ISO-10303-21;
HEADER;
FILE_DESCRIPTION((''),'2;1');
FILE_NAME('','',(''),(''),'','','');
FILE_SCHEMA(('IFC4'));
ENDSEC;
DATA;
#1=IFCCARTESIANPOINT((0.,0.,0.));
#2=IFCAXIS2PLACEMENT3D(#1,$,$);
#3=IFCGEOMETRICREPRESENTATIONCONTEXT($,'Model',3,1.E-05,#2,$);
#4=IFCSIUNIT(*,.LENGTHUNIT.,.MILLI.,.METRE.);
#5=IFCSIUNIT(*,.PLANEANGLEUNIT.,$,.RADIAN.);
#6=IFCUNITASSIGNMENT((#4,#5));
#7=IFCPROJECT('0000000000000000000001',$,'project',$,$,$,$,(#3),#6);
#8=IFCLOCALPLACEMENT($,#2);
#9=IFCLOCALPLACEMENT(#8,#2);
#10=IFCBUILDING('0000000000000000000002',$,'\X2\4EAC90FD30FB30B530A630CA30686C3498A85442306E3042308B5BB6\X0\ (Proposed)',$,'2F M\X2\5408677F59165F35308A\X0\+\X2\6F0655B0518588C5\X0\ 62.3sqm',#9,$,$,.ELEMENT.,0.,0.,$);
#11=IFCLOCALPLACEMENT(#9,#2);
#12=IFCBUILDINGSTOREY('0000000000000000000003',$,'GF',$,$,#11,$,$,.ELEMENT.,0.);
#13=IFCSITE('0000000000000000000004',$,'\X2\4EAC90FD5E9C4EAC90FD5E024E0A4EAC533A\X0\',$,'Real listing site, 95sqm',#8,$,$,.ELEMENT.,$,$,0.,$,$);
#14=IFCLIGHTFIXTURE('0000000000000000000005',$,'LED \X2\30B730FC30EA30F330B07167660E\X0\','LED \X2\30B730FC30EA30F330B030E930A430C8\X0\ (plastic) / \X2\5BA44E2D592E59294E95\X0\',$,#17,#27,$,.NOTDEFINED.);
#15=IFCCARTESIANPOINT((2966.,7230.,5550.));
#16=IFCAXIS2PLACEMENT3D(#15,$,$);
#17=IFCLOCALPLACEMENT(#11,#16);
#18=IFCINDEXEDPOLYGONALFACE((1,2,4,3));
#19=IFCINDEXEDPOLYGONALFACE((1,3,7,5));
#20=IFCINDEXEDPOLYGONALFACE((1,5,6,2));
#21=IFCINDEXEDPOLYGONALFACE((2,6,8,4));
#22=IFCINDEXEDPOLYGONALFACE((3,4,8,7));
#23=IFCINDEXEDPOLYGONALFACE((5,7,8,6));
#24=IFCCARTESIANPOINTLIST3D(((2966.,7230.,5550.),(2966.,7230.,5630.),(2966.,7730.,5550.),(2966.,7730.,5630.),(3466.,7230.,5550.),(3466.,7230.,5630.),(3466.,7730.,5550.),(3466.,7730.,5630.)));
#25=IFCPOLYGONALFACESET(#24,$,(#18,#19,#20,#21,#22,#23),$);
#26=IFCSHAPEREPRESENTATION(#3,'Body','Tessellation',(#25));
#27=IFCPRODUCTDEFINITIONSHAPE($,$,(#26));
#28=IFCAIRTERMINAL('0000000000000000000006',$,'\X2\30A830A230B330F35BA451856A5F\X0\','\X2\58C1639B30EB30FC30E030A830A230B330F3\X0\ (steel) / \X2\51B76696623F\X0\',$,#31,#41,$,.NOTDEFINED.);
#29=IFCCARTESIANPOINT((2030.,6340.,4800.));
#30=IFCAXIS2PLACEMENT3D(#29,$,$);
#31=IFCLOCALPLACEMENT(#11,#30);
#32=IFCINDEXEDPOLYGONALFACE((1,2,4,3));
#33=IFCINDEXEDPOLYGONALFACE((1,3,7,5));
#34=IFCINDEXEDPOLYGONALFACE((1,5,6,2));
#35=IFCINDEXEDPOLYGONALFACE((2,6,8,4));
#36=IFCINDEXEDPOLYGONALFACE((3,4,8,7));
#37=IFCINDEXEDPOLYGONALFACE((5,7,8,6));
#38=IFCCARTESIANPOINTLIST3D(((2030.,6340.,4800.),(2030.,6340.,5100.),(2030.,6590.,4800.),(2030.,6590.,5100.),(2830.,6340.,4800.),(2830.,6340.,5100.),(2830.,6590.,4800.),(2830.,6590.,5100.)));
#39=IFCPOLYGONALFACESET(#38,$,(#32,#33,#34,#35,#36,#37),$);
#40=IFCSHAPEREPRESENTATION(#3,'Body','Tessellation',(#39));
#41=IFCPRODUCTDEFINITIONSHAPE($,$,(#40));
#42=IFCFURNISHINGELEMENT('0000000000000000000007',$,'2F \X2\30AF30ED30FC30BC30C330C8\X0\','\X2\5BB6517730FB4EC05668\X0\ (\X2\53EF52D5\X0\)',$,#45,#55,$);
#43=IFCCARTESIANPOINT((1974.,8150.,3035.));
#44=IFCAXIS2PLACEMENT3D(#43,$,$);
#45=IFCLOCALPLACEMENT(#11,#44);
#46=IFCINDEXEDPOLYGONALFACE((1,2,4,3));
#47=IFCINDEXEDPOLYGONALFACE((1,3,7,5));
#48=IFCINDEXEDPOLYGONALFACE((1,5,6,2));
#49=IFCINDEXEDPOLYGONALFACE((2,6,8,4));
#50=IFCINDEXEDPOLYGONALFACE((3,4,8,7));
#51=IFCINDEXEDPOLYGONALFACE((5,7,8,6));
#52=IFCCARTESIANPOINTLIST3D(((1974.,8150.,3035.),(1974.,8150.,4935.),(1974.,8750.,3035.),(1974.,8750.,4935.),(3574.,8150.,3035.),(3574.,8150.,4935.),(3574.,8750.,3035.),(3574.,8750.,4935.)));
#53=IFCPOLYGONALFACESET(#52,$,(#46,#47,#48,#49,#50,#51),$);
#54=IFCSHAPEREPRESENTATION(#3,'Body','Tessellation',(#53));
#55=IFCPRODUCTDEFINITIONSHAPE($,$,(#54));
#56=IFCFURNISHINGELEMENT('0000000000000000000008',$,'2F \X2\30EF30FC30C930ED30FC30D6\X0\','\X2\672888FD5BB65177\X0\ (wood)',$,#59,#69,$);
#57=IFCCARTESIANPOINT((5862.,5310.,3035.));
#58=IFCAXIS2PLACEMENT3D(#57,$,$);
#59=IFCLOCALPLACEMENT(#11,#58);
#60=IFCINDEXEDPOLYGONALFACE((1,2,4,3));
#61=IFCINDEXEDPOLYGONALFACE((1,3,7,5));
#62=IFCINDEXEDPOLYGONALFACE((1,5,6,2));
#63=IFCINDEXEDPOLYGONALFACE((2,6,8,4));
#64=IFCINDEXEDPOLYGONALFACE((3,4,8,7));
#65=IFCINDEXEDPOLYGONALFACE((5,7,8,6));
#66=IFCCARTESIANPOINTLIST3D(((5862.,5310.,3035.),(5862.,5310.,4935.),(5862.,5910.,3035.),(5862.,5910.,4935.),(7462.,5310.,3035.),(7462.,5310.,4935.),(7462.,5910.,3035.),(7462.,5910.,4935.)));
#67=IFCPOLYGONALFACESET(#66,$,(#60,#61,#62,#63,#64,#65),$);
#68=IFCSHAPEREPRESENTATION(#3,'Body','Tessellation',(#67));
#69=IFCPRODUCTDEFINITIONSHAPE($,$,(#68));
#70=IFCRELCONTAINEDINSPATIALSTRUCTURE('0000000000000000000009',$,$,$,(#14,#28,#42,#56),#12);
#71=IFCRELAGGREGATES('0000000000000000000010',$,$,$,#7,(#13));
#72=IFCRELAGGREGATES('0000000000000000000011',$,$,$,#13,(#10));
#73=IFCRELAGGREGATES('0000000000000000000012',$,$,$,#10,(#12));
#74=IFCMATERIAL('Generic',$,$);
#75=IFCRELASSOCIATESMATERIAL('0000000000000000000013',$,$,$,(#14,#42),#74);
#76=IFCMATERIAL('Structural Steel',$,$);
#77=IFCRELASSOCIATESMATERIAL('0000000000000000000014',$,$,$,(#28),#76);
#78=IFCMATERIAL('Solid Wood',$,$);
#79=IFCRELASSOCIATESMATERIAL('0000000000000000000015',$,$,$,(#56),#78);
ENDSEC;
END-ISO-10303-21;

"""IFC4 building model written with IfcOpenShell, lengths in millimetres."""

from ifc_helpers import new_model, si_unit, frame, frame_2d, origin, place, context, project, spatial, rectangle, extrude, material, element, save


model = new_model("IFC4")

# Units and contexts
model_context = context("Model", 3, precision=1e-05, world=origin())
ifc_project = project(units=[si_unit("LENGTHUNIT", "METRE", prefix="MILLI"), si_unit("PLANEANGLEUNIT", "RADIAN")], contexts=[model_context])

# Site, building, storey
site_placement = place(None, origin())
site = spatial("IfcSite", under=ifc_project, at=site_placement, Name="京都府京都市上京区", ObjectType="Real listing site, 95sqm", CompositionType="ELEMENT", RefElevation=0.0)
building_placement = place(site_placement, origin())
building = spatial("IfcBuilding", under=site, at=building_placement, Name="京都・サウナと水風呂のある家 (Proposed)", ObjectType="2F M合板外張り+漆喰内装 62.3sqm", CompositionType="ELEMENT", ElevationOfRefHeight=0.0, ElevationOfTerrain=0.0)
storey_placement = place(building_placement, origin())
storey = spatial("IfcBuildingStorey", under=building, at=storey_placement, Name="GF", CompositionType="ELEMENT", Elevation=0.0)

# Shared definitions
ifc_material_1 = material(Name="Solid Wood")

# Shared definitions
ifc_material_2 = material(Name="Generic")

# Shared definitions
ifc_material_3 = material(Name="Structural Steel")

# Light fixture
light_fixture_1_placement = place(storey_placement, frame((2966.0, 7230.0, 5550.0)))
element("IfcLightFixture", 1, at=light_fixture_1_placement, inside=storey, material=ifc_material_2, Name="LED シーリング照明", Description="LED シーリングライト (plastic) / 室中央天井", PredefinedType="NOTDEFINED", context=model_context, shape_type="SweptSolid", body=[
    extrude(rectangle(XDim=500.0, YDim=500.0, at=frame_2d((250.0, 250.0))), frame((2966.0, 7230.0, 5550.0)), (0.0, 0.0, 1.0), 80.0),
])

# Air terminal
air_terminal_placement = place(storey_placement, frame((2030.0, 6340.0, 4800.0)))
element("IfcAirTerminal", 2, at=air_terminal_placement, inside=storey, material=ifc_material_3, Name="エアコン室内機", Description="壁掛ルームエアコン (steel) / 冷暖房", PredefinedType="NOTDEFINED", context=model_context, shape_type="SweptSolid", body=[
    extrude(rectangle(XDim=800.0, YDim=250.0, at=frame_2d((400.0, 125.0))), frame((2030.0, 6340.0, 4800.0)), (0.0, 0.0, 1.0), 300.0),
])

# Furnishing elements
furnishing_1_placement = place(storey_placement, frame((1974.0, 8150.0, 3035.0)))
element("IfcFurnishingElement", 3, at=furnishing_1_placement, inside=storey, material=ifc_material_2, Name="2F クローゼット", Description="家具・什器 (可動)", context=model_context, shape_type="SweptSolid", body=[
    extrude(rectangle(XDim=1600.0, YDim=600.0, at=frame_2d((800.0, 300.0))), frame((1974.0, 8150.0, 3035.0)), (0.0, 0.0, 1.0), 1900.0),
])
furnishing_2_placement = place(storey_placement, frame((5862.0, 5310.0, 3035.0)))
element("IfcFurnishingElement", 4, at=furnishing_2_placement, inside=storey, material=ifc_material_1, Name="2F ワードローブ", Description="木製家具 (wood)", context=model_context, shape_type="SweptSolid", body=[
    extrude(rectangle(XDim=1600.0, YDim=600.0, at=frame_2d((800.0, 300.0))), frame((5862.0, 5310.0, 3035.0)), (0.0, 0.0, 1.0), 1900.0),
])

save(model, "model.ifc")
